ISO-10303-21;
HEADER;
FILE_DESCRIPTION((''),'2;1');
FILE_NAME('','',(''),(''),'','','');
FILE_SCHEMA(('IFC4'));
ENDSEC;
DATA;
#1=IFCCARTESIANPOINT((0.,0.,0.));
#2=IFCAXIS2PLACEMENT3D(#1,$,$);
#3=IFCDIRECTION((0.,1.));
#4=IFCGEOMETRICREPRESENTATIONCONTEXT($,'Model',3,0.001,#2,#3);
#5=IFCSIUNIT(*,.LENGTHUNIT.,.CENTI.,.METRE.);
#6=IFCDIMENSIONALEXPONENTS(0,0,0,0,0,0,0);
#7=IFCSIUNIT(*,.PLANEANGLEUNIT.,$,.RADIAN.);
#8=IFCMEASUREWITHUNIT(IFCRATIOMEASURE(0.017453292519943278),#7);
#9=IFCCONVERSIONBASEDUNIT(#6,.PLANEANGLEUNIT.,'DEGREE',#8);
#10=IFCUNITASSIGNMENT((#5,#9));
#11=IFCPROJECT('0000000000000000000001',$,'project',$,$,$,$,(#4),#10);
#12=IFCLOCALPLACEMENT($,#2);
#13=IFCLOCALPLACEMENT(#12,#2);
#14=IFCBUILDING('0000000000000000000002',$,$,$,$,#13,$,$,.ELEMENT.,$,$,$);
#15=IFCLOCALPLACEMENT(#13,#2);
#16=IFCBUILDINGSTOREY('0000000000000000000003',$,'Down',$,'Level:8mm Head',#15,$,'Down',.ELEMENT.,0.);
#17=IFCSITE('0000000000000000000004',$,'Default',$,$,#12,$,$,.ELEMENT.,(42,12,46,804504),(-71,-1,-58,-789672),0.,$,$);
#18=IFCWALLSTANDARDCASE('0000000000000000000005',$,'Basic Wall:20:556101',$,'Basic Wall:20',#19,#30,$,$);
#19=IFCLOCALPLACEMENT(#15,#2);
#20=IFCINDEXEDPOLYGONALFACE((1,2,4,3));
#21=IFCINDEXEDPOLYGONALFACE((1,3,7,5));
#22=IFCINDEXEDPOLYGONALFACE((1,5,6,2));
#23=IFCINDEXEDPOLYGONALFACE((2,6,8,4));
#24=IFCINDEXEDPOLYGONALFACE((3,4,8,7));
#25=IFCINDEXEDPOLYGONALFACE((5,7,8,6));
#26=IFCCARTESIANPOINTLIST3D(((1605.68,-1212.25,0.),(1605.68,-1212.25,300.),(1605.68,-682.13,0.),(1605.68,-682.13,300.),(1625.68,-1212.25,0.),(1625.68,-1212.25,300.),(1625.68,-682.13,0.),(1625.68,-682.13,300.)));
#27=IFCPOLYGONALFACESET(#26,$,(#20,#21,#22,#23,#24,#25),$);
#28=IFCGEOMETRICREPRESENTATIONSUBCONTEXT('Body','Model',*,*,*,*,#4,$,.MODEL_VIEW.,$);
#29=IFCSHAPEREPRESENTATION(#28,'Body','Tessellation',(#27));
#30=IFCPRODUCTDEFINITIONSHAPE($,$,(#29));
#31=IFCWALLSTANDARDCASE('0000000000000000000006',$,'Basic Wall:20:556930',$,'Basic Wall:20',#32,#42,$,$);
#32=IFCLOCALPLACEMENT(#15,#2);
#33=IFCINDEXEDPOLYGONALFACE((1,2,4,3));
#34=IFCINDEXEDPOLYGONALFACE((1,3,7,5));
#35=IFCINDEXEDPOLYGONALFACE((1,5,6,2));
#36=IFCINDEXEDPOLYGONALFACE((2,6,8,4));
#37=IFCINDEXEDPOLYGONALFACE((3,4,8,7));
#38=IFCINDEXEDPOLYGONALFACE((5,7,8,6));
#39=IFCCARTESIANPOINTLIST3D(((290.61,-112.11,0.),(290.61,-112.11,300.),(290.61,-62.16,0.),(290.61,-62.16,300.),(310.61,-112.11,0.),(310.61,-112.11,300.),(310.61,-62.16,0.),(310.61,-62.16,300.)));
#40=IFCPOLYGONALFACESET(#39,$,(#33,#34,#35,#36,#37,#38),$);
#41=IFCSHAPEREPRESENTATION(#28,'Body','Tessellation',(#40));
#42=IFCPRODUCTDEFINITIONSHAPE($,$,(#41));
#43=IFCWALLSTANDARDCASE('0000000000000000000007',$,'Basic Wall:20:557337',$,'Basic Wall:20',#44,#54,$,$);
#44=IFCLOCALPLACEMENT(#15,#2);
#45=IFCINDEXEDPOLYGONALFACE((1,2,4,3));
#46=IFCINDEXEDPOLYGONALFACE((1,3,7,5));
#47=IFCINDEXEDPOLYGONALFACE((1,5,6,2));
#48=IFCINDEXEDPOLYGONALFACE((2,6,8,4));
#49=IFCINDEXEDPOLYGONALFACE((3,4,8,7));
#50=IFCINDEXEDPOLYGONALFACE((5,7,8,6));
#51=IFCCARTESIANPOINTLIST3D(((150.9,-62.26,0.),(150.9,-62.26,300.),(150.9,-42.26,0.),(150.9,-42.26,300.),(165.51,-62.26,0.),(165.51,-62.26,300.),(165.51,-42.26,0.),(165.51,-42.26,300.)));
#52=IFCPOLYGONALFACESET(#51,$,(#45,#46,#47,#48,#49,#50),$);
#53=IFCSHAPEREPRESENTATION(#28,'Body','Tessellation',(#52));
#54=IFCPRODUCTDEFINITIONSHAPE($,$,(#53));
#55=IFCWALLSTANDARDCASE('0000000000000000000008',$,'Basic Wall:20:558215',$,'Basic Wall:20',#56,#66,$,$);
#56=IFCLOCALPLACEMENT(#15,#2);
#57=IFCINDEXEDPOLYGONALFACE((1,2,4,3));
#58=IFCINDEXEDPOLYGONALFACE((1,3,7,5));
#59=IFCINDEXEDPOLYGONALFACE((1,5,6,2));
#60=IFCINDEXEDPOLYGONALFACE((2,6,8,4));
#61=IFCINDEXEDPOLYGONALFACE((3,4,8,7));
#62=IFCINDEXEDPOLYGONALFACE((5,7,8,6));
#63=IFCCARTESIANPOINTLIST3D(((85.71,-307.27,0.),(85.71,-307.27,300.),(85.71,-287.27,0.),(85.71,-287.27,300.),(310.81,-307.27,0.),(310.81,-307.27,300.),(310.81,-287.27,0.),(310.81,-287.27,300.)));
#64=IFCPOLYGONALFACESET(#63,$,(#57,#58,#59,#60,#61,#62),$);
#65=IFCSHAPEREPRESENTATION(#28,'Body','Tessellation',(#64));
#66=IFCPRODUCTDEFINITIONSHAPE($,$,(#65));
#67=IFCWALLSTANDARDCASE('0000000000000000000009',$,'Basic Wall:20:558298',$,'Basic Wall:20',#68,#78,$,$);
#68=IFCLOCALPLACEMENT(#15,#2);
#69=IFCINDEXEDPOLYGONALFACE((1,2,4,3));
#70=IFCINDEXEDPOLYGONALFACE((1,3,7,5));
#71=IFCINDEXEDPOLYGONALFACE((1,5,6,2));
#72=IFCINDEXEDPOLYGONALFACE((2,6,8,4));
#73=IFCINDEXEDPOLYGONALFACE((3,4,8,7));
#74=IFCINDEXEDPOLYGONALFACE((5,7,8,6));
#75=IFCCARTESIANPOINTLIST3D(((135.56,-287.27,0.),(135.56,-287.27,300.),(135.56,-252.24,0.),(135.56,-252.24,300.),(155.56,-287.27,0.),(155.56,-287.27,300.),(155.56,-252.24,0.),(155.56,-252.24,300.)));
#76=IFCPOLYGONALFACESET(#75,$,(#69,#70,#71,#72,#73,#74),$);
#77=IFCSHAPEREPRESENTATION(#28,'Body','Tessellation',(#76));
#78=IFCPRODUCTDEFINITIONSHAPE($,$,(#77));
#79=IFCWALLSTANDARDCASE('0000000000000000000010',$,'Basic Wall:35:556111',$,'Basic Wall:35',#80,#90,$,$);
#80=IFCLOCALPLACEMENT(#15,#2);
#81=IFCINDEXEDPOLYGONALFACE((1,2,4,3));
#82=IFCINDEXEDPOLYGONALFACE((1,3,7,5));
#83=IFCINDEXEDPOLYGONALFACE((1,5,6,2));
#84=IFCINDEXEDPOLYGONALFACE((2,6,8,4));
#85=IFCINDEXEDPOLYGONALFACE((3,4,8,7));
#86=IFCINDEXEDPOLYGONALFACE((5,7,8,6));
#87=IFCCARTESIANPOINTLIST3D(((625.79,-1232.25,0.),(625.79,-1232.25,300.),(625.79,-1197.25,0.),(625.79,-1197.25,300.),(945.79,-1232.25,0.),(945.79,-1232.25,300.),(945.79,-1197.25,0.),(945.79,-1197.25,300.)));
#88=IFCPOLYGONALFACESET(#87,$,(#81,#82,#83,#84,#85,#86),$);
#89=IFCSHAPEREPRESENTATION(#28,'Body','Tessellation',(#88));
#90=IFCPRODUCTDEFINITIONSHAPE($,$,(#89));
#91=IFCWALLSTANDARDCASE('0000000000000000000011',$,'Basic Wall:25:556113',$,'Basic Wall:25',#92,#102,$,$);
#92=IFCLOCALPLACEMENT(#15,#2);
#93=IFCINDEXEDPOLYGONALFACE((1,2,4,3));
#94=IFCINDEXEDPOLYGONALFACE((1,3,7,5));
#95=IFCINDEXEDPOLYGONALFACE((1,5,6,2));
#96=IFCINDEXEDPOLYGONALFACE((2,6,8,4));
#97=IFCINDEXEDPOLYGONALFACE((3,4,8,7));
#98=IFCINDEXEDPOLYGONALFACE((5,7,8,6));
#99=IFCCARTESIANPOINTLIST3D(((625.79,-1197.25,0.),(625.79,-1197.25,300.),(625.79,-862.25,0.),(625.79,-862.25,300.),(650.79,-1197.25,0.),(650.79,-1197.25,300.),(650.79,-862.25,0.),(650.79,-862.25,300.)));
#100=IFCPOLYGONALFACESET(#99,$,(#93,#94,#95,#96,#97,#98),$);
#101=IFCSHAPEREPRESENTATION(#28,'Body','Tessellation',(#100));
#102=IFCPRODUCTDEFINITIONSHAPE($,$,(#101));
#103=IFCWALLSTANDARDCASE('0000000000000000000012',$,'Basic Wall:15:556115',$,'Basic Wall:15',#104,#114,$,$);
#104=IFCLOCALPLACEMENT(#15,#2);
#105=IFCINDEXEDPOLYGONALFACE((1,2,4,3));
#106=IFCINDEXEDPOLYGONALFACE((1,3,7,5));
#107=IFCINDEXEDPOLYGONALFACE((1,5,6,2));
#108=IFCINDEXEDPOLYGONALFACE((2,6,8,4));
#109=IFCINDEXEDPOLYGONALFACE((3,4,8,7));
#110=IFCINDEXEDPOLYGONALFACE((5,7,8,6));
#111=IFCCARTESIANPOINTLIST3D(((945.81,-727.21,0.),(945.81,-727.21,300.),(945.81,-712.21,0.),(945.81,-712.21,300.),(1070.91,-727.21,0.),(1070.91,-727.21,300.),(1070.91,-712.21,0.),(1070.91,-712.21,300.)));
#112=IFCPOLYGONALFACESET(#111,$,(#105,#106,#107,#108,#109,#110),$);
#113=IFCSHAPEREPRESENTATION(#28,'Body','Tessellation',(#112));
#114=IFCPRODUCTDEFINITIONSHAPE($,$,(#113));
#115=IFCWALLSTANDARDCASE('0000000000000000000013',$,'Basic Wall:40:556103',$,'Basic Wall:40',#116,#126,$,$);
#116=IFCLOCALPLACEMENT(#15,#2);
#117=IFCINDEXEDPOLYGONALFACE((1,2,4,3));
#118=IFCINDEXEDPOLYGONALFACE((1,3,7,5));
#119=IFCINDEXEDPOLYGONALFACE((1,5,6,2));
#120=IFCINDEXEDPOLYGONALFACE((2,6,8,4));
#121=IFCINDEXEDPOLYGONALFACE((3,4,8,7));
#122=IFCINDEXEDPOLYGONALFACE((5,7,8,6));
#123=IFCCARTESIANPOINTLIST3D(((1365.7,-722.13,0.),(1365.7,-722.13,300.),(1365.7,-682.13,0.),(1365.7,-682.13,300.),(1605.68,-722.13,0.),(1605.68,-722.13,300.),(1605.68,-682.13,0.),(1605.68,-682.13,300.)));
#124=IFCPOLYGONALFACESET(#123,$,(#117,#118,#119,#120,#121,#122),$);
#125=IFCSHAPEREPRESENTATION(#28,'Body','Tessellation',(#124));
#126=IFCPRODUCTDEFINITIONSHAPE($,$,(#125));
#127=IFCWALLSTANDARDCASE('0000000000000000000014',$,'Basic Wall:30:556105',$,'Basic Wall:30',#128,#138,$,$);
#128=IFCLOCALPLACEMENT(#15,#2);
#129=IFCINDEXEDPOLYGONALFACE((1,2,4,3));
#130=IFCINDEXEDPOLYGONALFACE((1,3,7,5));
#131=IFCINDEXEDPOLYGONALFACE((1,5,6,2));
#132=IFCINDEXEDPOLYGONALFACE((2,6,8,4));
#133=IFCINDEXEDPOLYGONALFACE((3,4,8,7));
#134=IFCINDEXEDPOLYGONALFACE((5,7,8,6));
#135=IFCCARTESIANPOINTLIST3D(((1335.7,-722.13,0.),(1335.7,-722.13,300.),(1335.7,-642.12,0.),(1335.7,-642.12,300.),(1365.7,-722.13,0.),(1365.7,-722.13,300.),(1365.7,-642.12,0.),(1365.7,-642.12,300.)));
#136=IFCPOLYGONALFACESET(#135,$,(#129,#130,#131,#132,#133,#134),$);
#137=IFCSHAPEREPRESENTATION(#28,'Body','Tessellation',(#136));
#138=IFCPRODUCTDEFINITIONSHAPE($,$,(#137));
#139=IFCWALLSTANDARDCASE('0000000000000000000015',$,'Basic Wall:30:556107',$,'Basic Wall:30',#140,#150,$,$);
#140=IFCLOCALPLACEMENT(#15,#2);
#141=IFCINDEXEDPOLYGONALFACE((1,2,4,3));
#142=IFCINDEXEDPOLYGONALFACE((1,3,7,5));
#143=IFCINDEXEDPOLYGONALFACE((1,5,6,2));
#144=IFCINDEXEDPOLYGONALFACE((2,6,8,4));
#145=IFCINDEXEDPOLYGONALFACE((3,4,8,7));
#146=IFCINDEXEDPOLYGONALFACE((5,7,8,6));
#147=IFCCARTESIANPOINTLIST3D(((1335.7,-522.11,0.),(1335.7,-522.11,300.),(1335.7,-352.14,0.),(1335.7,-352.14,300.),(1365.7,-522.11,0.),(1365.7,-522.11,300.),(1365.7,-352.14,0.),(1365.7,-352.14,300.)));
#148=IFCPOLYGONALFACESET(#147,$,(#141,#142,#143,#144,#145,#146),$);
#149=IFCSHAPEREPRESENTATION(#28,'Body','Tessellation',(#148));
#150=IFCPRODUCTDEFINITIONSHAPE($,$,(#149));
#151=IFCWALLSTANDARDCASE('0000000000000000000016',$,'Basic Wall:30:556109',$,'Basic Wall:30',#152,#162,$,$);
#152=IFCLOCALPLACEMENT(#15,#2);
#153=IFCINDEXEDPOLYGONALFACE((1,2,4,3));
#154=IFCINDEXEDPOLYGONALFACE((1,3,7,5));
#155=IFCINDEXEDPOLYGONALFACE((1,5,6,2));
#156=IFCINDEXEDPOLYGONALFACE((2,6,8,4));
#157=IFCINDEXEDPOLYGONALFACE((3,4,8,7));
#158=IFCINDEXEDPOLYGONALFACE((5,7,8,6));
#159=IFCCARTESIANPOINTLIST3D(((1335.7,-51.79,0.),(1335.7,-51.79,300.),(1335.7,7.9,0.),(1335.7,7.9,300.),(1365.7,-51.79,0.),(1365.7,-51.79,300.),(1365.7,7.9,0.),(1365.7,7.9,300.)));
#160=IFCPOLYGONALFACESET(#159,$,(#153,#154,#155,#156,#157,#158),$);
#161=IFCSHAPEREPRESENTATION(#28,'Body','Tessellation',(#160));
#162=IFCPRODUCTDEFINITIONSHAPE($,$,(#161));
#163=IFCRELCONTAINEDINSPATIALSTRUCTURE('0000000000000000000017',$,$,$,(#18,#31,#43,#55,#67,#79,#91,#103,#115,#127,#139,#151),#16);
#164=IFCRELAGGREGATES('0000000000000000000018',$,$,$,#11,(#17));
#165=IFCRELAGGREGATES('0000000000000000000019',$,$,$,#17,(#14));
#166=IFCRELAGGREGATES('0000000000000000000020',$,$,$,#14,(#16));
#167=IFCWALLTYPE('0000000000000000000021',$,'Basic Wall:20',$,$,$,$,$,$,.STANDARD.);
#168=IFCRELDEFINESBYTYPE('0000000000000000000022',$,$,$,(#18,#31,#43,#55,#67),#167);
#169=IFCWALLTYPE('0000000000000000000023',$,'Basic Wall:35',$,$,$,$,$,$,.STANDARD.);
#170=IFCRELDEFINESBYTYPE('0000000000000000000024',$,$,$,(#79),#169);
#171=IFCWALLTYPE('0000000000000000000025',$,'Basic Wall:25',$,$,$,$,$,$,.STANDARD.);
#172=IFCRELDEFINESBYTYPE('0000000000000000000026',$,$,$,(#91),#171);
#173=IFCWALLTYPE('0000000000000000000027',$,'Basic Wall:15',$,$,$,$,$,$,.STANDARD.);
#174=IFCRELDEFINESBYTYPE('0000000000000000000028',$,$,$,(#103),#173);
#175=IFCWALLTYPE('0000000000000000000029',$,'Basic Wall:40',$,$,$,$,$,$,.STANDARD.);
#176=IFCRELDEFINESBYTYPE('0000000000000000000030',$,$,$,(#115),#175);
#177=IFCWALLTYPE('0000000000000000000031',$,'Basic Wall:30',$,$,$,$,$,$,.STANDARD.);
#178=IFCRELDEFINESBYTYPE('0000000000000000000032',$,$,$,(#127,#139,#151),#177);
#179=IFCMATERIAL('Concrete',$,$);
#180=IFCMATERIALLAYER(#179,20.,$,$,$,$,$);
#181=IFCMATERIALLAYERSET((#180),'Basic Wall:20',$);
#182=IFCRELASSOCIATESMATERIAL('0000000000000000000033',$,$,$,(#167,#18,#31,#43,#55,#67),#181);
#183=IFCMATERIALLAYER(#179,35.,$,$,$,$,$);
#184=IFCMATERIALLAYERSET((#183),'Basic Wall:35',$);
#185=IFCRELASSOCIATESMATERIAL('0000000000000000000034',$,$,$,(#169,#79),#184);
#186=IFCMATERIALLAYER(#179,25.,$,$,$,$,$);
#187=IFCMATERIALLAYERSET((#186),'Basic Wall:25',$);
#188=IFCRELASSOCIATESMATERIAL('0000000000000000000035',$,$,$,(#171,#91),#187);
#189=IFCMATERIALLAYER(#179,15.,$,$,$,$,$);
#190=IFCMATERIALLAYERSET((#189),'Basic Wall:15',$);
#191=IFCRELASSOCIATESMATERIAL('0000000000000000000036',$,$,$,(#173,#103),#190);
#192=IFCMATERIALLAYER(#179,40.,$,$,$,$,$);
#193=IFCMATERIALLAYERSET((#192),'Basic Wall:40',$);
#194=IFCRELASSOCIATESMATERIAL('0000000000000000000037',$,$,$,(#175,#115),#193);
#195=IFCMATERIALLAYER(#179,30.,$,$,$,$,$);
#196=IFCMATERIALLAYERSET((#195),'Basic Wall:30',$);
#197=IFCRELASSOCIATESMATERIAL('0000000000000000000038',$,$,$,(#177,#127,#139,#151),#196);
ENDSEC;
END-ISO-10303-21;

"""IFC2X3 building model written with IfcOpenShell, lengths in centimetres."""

from ifc_helpers import new_model, entity, si_unit, converted_unit, direction, frame, frame_2d, origin, place, context, subcontext, project, spatial, rectangle, extrude, material, layer, layer_set, layer_usage, type_object, element, save


model = new_model("IFC2X3")

# Units and contexts
model_context = context("Model", 3, precision=0.001, world=origin(), true_north=direction((0.0, 1.0)))
body_context = subcontext(model_context, "Body", "Model", "MODEL_VIEW")
ifc_project = project(units=[si_unit("LENGTHUNIT", "METRE", prefix="CENTI"), converted_unit("PLANEANGLEUNIT", "DEGREE", entity("IfcRatioMeasure", 0.017453292519943278), si_unit("PLANEANGLEUNIT", "RADIAN"), dimensions=[0, 0, 0, 0, 0, 0, 0])], contexts=[model_context])

# Site, building, storey
site_placement = place(None, origin())
site = spatial("IfcSite", under=ifc_project, at=site_placement, Name="Default", CompositionType="ELEMENT", RefLatitude=(42, 12, 46, 804504), RefLongitude=(-71, -1, -58, -789672), RefElevation=0.0)
building_placement = place(site_placement, origin())
building = spatial("IfcBuilding", under=site, at=building_placement, CompositionType="ELEMENT")
storey_placement = place(building_placement, origin())
storey = spatial("IfcBuildingStorey", under=building, at=storey_placement, Name="Down", ObjectType="Level:8mm Head", LongName="Down", CompositionType="ELEMENT", Elevation=0.0)

# Walls
ifc_material = material(Name="Concrete")
ifc_layer_1 = layer(ifc_material, 20.0)
ifc_layer_set_1 = layer_set([ifc_layer_1], Name="Basic Wall:20")
wall_type_1 = type_object("IfcWallType", Name="Basic Wall:20", PredefinedType="STANDARD", material=ifc_layer_set_1)
ifc_layer_usage_1 = layer_usage(ifc_layer_set_1, "AXIS2", "POSITIVE", -10.0)
wall_1_placement = place(storey_placement, frame((1615.68, -1212.25, 0.0), z_axis=(0.0, 0.0, 1.0), x_axis=(0.0, 1.0, 0.0)))
element("IfcWallStandardCase", 1, at=wall_1_placement, inside=storey, type_object=wall_type_1, material=ifc_layer_usage_1, Name="Basic Wall:20:556101", ObjectType="Basic Wall:20", context=body_context, shape_type="SweptSolid", body=[
    extrude(rectangle(XDim=530.12, YDim=20.0, at=frame_2d((265.06, 0.0), x_axis=(-1.0, 0.0))), origin(), (0.0, 0.0, 1.0), 300.0),
])
ifc_layer_usage_2 = layer_usage(ifc_layer_set_1, "AXIS2", "NEGATIVE", 10.0)
wall_2_placement = place(storey_placement, frame((300.61, -112.11, 0.0), z_axis=(0.0, 0.0, 1.0), x_axis=(0.0, 1.0, 0.0)))
element("IfcWallStandardCase", 2, at=wall_2_placement, inside=storey, type_object=wall_type_1, material=ifc_layer_usage_2, Name="Basic Wall:20:556930", ObjectType="Basic Wall:20", context=body_context, shape_type="SweptSolid", body=[
    extrude(rectangle(XDim=49.95, YDim=20.0, at=frame_2d((24.98, 0.0), x_axis=(-1.0, 0.0))), origin(), (0.0, 0.0, 1.0), 300.0),
])
ifc_layer_usage_3 = layer_usage(ifc_layer_set_1, "AXIS2", "NEGATIVE", 10.0)
wall_3_placement = place(storey_placement, frame((150.9, -52.26, 0.0)))
element("IfcWallStandardCase", 3, at=wall_3_placement, inside=storey, type_object=wall_type_1, material=ifc_layer_usage_3, Name="Basic Wall:20:557337", ObjectType="Basic Wall:20", context=body_context, shape_type="SweptSolid", body=[
    extrude(rectangle(XDim=14.61, YDim=20.0, at=frame_2d((7.3, 0.0), x_axis=(-1.0, 0.0))), origin(), (0.0, 0.0, 1.0), 300.0),
])
ifc_layer_usage_4 = layer_usage(ifc_layer_set_1, "AXIS2", "POSITIVE", -10.0)
wall_4_placement = place(storey_placement, frame((85.71, -297.27, 0.0)))
element("IfcWallStandardCase", 4, at=wall_4_placement, inside=storey, type_object=wall_type_1, material=ifc_layer_usage_4, Name="Basic Wall:20:558215", ObjectType="Basic Wall:20", context=body_context, shape_type="SweptSolid", body=[
    extrude(rectangle(XDim=225.09, YDim=20.0, at=frame_2d((112.55, 0.0), x_axis=(-1.0, 0.0))), origin(), (0.0, 0.0, 1.0), 300.0),
])
ifc_layer_usage_5 = layer_usage(ifc_layer_set_1, "AXIS2", "NEGATIVE", 10.0)
wall_5_placement = place(storey_placement, frame((145.56, -252.24, 0.0), z_axis=(0.0, 0.0, 1.0), x_axis=(0.0, -1.0, 0.0)))
element("IfcWallStandardCase", 5, at=wall_5_placement, inside=storey, type_object=wall_type_1, material=ifc_layer_usage_5, Name="Basic Wall:20:558298", ObjectType="Basic Wall:20", context=body_context, shape_type="SweptSolid", body=[
    extrude(rectangle(XDim=35.03, YDim=20.0, at=frame_2d((17.52, 0.0), x_axis=(-1.0, 0.0))), origin(), (0.0, 0.0, 1.0), 300.0),
])
ifc_layer_2 = layer(ifc_material, 35.0)
ifc_layer_set_2 = layer_set([ifc_layer_2], Name="Basic Wall:35")
ifc_layer_usage_6 = layer_usage(ifc_layer_set_2, "AXIS2", "NEGATIVE", 17.5)
wall_type_2 = type_object("IfcWallType", Name="Basic Wall:35", PredefinedType="STANDARD", material=ifc_layer_set_2)
wall_6_placement = place(storey_placement, frame((945.79, -1214.75, 0.0), z_axis=(0.0, 0.0, 1.0), x_axis=(-1.0, 0.0, 0.0)))
element("IfcWallStandardCase", 6, at=wall_6_placement, inside=storey, type_object=wall_type_2, material=ifc_layer_usage_6, Name="Basic Wall:35:556111", ObjectType="Basic Wall:35", context=body_context, shape_type="SweptSolid", body=[
    extrude(rectangle(XDim=320.0, YDim=35.0, at=frame_2d((160.0, 0.0), x_axis=(-1.0, 0.0))), origin(), (0.0, 0.0, 1.0), 300.0),
])
ifc_layer_3 = layer(ifc_material, 25.0)
ifc_layer_set_3 = layer_set([ifc_layer_3], Name="Basic Wall:25")
ifc_layer_usage_7 = layer_usage(ifc_layer_set_3, "AXIS2", "NEGATIVE", 12.5)
wall_type_3 = type_object("IfcWallType", Name="Basic Wall:25", PredefinedType="STANDARD", material=ifc_layer_set_3)
wall_7_placement = place(storey_placement, frame((638.29, -1197.25, 0.0), z_axis=(0.0, 0.0, 1.0), x_axis=(0.0, 1.0, 0.0)))
element("IfcWallStandardCase", 7, at=wall_7_placement, inside=storey, type_object=wall_type_3, material=ifc_layer_usage_7, Name="Basic Wall:25:556113", ObjectType="Basic Wall:25", context=body_context, shape_type="SweptSolid", body=[
    extrude(rectangle(XDim=334.99, YDim=25.0, at=frame_2d((167.5, 0.0), x_axis=(-1.0, 0.0))), origin(), (0.0, 0.0, 1.0), 300.0),
])
ifc_layer_4 = layer(ifc_material, 15.0)
ifc_layer_set_4 = layer_set([ifc_layer_4], Name="Basic Wall:15")
ifc_layer_usage_8 = layer_usage(ifc_layer_set_4, "AXIS2", "NEGATIVE", 7.5)
wall_type_4 = type_object("IfcWallType", Name="Basic Wall:15", PredefinedType="STANDARD", material=ifc_layer_set_4)
wall_8_placement = place(storey_placement, frame((1070.91, -719.71, 0.0), z_axis=(0.0, 0.0, 1.0), x_axis=(-1.0, 0.0, 0.0)))
element("IfcWallStandardCase", 8, at=wall_8_placement, inside=storey, type_object=wall_type_4, material=ifc_layer_usage_8, Name="Basic Wall:15:556115", ObjectType="Basic Wall:15", context=body_context, shape_type="SweptSolid", body=[
    extrude(rectangle(XDim=125.09, YDim=15.0, at=frame_2d((62.55, 0.0), x_axis=(-1.0, 0.0))), origin(), (0.0, 0.0, 1.0), 300.0),
])
ifc_layer_5 = layer(ifc_material, 40.0)
ifc_layer_set_5 = layer_set([ifc_layer_5], Name="Basic Wall:40")
ifc_layer_usage_9 = layer_usage(ifc_layer_set_5, "AXIS2", "POSITIVE", -20.0)
wall_type_5 = type_object("IfcWallType", Name="Basic Wall:40", PredefinedType="STANDARD", material=ifc_layer_set_5)
wall_9_placement = place(storey_placement, frame((1605.68, -702.13, 0.0), z_axis=(0.0, 0.0, 1.0), x_axis=(-1.0, 0.0, 0.0)))
element("IfcWallStandardCase", 9, at=wall_9_placement, inside=storey, type_object=wall_type_5, material=ifc_layer_usage_9, Name="Basic Wall:40:556103", ObjectType="Basic Wall:40", context=body_context, shape_type="SweptSolid", body=[
    extrude(rectangle(XDim=239.98, YDim=40.0, at=frame_2d((119.99, 0.0), x_axis=(-1.0, 0.0))), origin(), (0.0, 0.0, 1.0), 300.0),
])
ifc_layer_6 = layer(ifc_material, 30.0)
ifc_layer_set_6 = layer_set([ifc_layer_6], Name="Basic Wall:30")
ifc_layer_usage_10 = layer_usage(ifc_layer_set_6, "AXIS2", "NEGATIVE", 15.0)
wall_type_6 = type_object("IfcWallType", Name="Basic Wall:30", PredefinedType="STANDARD", material=ifc_layer_set_6)
wall_10_placement = place(storey_placement, frame((1350.7, -722.13, 0.0), z_axis=(0.0, 0.0, 1.0), x_axis=(0.0, 1.0, 0.0)))
element("IfcWallStandardCase", 10, at=wall_10_placement, inside=storey, type_object=wall_type_6, material=ifc_layer_usage_10, Name="Basic Wall:30:556105", ObjectType="Basic Wall:30", context=body_context, shape_type="SweptSolid", body=[
    extrude(rectangle(XDim=80.0, YDim=30.0, at=frame_2d((40.0, 0.0), x_axis=(-1.0, 0.0))), origin(), (0.0, 0.0, 1.0), 300.0),
])
ifc_layer_usage_11 = layer_usage(ifc_layer_set_6, "AXIS2", "NEGATIVE", 15.0)
wall_11_placement = place(storey_placement, frame((1350.7, -522.11, 0.0), z_axis=(0.0, 0.0, 1.0), x_axis=(0.0, 1.0, 0.0)))
element("IfcWallStandardCase", 11, at=wall_11_placement, inside=storey, type_object=wall_type_6, material=ifc_layer_usage_11, Name="Basic Wall:30:556107", ObjectType="Basic Wall:30", context=body_context, shape_type="SweptSolid", body=[
    extrude(rectangle(XDim=169.97, YDim=30.0, at=frame_2d((84.98, 0.0), x_axis=(-1.0, 0.0))), origin(), (0.0, 0.0, 1.0), 300.0),
])
ifc_layer_usage_12 = layer_usage(ifc_layer_set_6, "AXIS2", "NEGATIVE", 15.0)
wall_12_placement = place(storey_placement, frame((1350.7, -51.79, 0.0), z_axis=(0.0, 0.0, 1.0), x_axis=(0.0, 1.0, 0.0)))
element("IfcWallStandardCase", 12, at=wall_12_placement, inside=storey, type_object=wall_type_6, material=ifc_layer_usage_12, Name="Basic Wall:30:556109", ObjectType="Basic Wall:30", context=body_context, shape_type="SweptSolid", body=[
    extrude(rectangle(XDim=59.69, YDim=30.0, at=frame_2d((29.84, 0.0), x_axis=(-1.0, 0.0))), origin(), (0.0, 0.0, 1.0), 300.0),
])

save(model, "model.ifc")
